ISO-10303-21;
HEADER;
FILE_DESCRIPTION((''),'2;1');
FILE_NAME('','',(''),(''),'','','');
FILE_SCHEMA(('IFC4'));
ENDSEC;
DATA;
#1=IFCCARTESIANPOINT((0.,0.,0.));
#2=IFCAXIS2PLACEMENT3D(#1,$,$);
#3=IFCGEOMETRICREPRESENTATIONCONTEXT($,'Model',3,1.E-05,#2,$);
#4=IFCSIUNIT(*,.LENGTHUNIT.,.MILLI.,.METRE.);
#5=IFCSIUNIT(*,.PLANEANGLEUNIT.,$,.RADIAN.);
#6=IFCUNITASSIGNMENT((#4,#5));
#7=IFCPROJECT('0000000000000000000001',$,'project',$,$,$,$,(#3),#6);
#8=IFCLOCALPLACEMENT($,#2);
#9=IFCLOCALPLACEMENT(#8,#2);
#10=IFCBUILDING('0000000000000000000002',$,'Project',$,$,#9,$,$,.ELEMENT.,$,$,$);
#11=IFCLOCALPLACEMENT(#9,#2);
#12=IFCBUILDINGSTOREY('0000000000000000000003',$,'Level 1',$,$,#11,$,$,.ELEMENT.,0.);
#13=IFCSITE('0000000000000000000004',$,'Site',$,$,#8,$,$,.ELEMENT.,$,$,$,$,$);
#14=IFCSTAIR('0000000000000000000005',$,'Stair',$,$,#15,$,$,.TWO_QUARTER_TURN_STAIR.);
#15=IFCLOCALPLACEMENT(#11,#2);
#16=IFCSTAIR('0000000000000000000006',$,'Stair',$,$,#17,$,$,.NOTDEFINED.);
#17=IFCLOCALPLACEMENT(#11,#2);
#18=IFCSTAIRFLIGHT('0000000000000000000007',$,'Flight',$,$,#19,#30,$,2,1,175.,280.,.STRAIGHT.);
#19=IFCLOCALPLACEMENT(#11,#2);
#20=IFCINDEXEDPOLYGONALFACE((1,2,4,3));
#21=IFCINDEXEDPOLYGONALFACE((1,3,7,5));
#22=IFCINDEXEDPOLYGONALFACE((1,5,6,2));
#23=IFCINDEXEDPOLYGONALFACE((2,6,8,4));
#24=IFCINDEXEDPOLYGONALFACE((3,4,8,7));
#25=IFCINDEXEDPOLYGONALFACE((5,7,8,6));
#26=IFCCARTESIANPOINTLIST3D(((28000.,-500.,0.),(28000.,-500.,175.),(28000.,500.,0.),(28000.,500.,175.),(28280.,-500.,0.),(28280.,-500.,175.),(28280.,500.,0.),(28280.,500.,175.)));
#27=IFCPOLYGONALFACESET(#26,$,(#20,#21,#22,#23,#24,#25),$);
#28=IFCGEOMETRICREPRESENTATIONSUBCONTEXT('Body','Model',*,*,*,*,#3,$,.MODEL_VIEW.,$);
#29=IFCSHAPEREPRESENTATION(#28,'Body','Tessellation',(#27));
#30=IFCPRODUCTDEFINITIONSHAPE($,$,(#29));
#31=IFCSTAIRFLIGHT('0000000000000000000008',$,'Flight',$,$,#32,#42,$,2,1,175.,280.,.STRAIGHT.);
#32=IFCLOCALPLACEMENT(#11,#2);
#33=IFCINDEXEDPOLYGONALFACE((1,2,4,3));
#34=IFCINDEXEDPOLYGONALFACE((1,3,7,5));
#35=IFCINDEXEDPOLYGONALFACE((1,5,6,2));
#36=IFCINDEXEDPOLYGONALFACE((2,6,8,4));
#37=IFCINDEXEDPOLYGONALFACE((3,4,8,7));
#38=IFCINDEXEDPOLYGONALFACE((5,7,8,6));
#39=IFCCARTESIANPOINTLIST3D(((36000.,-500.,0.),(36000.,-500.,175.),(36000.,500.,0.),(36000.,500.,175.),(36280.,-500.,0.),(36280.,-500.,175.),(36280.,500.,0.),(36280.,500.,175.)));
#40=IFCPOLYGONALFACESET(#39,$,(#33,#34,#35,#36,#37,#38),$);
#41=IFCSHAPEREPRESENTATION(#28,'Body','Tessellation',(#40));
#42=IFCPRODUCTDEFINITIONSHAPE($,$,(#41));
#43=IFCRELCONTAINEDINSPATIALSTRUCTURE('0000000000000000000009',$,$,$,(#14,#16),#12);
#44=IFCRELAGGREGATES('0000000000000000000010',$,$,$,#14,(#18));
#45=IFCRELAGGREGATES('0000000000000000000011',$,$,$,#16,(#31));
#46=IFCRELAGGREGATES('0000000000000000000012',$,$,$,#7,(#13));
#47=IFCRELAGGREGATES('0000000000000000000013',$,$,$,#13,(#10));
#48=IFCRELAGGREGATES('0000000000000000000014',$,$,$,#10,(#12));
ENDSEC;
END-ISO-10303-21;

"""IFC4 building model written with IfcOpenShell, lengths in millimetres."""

from ifc_helpers import new_model, si_unit, frame, frame_2d, origin, place, context, subcontext, project, spatial, rectangle, extrude, element, aggregate, save


model = new_model("IFC4")

# Units and contexts
model_context = context("Model", 3, precision=1e-05, world=origin())
body_context = subcontext(model_context, "Body", "Model", "MODEL_VIEW")
ifc_project = project(units=[si_unit("LENGTHUNIT", "METRE", prefix="MILLI"), si_unit("PLANEANGLEUNIT", "RADIAN")], contexts=[model_context])

# Site, building, storey
site_placement = place(None, origin())
site = spatial("IfcSite", under=ifc_project, at=site_placement, Name="Site", CompositionType="ELEMENT")
building_placement = place(site_placement, origin())
building = spatial("IfcBuilding", under=site, at=building_placement, Name="Project", CompositionType="ELEMENT")
storey_placement = place(building_placement, origin())
storey = spatial("IfcBuildingStorey", under=building, at=storey_placement, Name="Level 1", CompositionType="ELEMENT", Elevation=0.0)

# Stairs
stair_1_placement = place(storey_placement, origin())
stair_1 = element("IfcStair", 1, at=stair_1_placement, inside=storey, Name="Stair", PredefinedType="TWO_QUARTER_TURN_STAIR")
stair_2_placement = place(storey_placement, origin())
stair_2 = element("IfcStair", 2, at=stair_2_placement, inside=storey, Name="Stair", PredefinedType="NOTDEFINED")

# Stair flights
stair_flight_1_placement = place(stair_1_placement, frame((28000.0, 0.0, 0.0), z_axis=(0.0, 0.0, 1.0), x_axis=(1.0, 0.0, 0.0)))
stair_flight_1 = element("IfcStairFlight", 3, at=stair_flight_1_placement, Name="Flight", NumberOfRisers=2, NumberOfTreads=1, PredefinedType="STRAIGHT", RiserHeight=175.0, TreadLength=280.0, context=body_context, shape_type="SweptSolid", body=[
    extrude(rectangle(XDim=280.0, YDim=1000.0, at=frame_2d((140.0, 0.0))), origin(), (0.0, 0.0, 1.0), 175.0),
])
aggregate(stair_1, [stair_flight_1])
stair_flight_2_placement = place(stair_2_placement, frame((36000.0, 0.0, 0.0), z_axis=(0.0, 0.0, 1.0), x_axis=(1.0, 0.0, 0.0)))
stair_flight_2 = element("IfcStairFlight", 4, at=stair_flight_2_placement, Name="Flight", NumberOfRisers=2, NumberOfTreads=1, PredefinedType="STRAIGHT", RiserHeight=175.0, TreadLength=280.0, context=body_context, shape_type="SweptSolid", body=[
    extrude(rectangle(XDim=280.0, YDim=1000.0, at=frame_2d((140.0, 0.0))), origin(), (0.0, 0.0, 1.0), 175.0),
])
aggregate(stair_2, [stair_flight_2])

save(model, "model.ifc")
